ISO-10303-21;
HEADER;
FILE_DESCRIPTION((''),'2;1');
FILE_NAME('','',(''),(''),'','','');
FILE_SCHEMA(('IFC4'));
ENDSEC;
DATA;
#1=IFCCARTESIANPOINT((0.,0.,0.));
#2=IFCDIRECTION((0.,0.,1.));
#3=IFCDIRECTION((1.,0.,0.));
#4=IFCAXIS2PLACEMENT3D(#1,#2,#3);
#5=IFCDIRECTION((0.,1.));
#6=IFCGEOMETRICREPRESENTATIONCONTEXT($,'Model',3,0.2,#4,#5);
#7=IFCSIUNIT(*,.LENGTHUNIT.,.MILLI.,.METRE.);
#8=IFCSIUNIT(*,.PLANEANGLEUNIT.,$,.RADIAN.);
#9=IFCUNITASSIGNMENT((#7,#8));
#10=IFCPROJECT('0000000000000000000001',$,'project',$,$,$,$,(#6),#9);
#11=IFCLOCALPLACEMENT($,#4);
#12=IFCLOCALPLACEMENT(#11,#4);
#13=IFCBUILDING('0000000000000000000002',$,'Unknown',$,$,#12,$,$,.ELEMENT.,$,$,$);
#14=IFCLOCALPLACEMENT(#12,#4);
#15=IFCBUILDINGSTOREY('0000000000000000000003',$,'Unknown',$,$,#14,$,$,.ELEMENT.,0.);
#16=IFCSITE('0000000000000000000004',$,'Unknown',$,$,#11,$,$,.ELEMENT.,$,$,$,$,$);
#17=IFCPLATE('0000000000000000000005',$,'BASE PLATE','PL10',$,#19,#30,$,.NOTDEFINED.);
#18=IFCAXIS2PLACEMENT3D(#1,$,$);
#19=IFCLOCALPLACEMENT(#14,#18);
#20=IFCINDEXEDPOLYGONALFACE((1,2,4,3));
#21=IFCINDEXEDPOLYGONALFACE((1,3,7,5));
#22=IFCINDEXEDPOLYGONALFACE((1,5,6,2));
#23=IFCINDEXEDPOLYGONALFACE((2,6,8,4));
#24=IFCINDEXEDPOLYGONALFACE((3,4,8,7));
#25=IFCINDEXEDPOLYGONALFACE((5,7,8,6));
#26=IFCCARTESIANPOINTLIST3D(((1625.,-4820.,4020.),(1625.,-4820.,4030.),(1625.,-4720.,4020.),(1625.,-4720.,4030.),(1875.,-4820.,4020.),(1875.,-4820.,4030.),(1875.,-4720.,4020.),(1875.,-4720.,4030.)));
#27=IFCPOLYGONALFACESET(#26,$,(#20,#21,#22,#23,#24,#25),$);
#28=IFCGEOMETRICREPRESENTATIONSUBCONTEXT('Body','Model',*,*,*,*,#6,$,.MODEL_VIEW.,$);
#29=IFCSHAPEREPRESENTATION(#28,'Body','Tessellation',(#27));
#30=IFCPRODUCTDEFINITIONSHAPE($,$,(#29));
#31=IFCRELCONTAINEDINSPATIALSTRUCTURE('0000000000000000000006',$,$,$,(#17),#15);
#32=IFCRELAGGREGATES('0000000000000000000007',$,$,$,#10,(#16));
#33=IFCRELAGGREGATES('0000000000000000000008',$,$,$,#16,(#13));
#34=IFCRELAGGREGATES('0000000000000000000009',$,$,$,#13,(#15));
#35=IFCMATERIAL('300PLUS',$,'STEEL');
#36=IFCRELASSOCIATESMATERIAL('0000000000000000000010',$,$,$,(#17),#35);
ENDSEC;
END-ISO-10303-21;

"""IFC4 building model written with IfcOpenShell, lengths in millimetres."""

from ifc_helpers import new_model, si_unit, direction, frame, origin_with_axes, place, context, subcontext, project, spatial, line, indexed_curve, outline, extrude, material, element, save


model = new_model("IFC4")

# Units and contexts
model_context = context("Model", 3, precision=0.2, world=origin_with_axes(), true_north=direction((0.0, 1.0)))
body_context = subcontext(model_context, "Body", "Model", "MODEL_VIEW")
ifc_project = project(units=[si_unit("LENGTHUNIT", "METRE", prefix="MILLI"), si_unit("PLANEANGLEUNIT", "RADIAN")], contexts=[model_context])

# Site, building, storey
site_placement = place(None, origin_with_axes())
site = spatial("IfcSite", under=ifc_project, at=site_placement, Name="Unknown", CompositionType="ELEMENT")
building_placement = place(site_placement, origin_with_axes())
building = spatial("IfcBuilding", under=site, at=building_placement, Name="Unknown", CompositionType="ELEMENT")
storey_placement = place(building_placement, origin_with_axes())
storey = spatial("IfcBuildingStorey", under=building, at=storey_placement, Name="Unknown", CompositionType="ELEMENT", Elevation=0.0)

# Shared definitions
ifc_material_1 = material(Name="300PLUS", Category="STEEL")

# Plate
plate_1_placement = place(storey_placement, frame((1625.0, -4820.0, 4025.0), z_axis=(0.0, 0.0, 1.0), x_axis=(1.0, 0.0, 0.0)))
element("IfcPlate", 1, at=plate_1_placement, inside=storey, material=ifc_material_1, Name="BASE PLATE", Description="PL10", PredefinedType="NOTDEFINED", context=body_context, shape_type="SolidModel", body=[
    extrude(outline(indexed_curve([(0.0, 0.0), (250.0, 0.0), (250.0, 100.0), (0.0, 100.0)], segments=[line(1, 2, 3, 4, 1)])), frame((0.0, 0.0, 5.0), z_axis=(0.0, 0.0, 1.0), x_axis=(1.0, 0.0, 0.0)), (0.0, 0.0, -1.0), 10.0),
])

save(model, "model.ifc")
